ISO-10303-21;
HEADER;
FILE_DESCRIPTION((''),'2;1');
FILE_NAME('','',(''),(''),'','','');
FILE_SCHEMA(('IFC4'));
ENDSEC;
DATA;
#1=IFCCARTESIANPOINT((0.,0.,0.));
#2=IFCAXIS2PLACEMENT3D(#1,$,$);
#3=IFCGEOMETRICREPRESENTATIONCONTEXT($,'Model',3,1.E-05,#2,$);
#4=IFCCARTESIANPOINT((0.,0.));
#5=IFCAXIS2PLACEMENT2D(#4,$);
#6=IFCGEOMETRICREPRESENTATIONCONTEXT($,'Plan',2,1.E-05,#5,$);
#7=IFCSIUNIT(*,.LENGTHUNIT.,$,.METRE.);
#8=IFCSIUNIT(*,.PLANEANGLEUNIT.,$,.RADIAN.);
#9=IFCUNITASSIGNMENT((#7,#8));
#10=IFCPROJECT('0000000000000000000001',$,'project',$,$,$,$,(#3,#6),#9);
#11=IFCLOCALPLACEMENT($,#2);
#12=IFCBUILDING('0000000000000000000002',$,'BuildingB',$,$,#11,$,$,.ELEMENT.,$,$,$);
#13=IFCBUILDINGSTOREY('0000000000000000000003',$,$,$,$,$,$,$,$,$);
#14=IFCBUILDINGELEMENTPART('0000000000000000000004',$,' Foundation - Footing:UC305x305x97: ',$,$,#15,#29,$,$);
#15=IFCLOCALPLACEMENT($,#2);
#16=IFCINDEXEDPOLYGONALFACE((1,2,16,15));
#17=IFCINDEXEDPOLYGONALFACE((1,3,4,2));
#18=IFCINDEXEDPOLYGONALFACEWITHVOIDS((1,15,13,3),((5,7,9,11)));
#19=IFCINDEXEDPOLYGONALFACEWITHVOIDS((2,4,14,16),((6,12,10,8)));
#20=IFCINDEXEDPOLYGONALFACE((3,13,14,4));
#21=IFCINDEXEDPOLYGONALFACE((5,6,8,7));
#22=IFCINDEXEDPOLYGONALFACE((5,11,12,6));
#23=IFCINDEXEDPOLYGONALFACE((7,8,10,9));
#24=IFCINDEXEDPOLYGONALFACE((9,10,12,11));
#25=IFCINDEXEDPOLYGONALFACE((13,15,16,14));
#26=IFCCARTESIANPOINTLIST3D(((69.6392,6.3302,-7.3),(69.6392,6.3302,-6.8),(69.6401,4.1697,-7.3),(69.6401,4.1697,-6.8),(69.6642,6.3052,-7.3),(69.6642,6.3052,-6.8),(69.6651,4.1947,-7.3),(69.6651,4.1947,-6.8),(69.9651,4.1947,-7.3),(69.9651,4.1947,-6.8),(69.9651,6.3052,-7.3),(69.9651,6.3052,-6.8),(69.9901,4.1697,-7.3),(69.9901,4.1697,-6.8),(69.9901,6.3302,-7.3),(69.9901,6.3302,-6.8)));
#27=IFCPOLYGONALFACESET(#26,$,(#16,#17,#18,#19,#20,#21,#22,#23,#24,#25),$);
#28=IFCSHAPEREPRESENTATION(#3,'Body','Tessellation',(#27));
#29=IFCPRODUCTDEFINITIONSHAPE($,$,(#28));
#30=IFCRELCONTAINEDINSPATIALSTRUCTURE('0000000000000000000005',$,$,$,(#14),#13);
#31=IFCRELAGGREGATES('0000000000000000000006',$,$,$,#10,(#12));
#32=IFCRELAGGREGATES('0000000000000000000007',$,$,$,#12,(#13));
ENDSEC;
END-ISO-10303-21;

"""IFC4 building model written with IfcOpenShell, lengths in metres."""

from ifc_helpers import new_model, si_unit, origin, origin_2d, place, context, project, spatial, polyline, outline, extrude, element, save


model = new_model("IFC4")

# Units and contexts
model_context = context("Model", 3, precision=1e-05, world=origin())
plan_context = context("Plan", 2, precision=1e-05, world=origin_2d())
ifc_project = project(units=[si_unit("LENGTHUNIT", "METRE"), si_unit("PLANEANGLEUNIT", "RADIAN")], contexts=[model_context, plan_context])

# Building, storey
building_placement = place(None, origin())
building = spatial("IfcBuilding", under=ifc_project, at=building_placement, Name="BuildingB", CompositionType="ELEMENT")
storey = spatial("IfcBuildingStorey", under=building)

# Building element part, opening
building_element_part_1 = element("IfcBuildingElementPart", 1, inside=storey, Name=" Foundation - Footing:UC305x305x97: ", context=model_context, shape_type="SweptSolid", body=[
    extrude(outline(polyline([(69.9901, 4.1697, -7.3), (69.6401, 4.1697, -7.3), (69.6392, 6.3302, -7.3), (69.9901, 6.3302, -7.3), (69.9901, 4.1697, -7.3)])), None, (0.0, 0.0, 1.0), 0.5),
])
element("IfcOpeningElement", 2, inside=storey, cuts=building_element_part_1, context=model_context, shape_type="SweptSolid", body=[
    extrude(outline(polyline([(69.9651, 4.1947, -7.3), (69.6651, 4.1947, -7.3), (69.6642, 6.3052, -7.3), (69.9651, 6.3052, -7.3), (69.9651, 4.1947, -7.3)])), None, (0.0, 0.0, 1.0), 0.5),
])

save(model, "model.ifc")
